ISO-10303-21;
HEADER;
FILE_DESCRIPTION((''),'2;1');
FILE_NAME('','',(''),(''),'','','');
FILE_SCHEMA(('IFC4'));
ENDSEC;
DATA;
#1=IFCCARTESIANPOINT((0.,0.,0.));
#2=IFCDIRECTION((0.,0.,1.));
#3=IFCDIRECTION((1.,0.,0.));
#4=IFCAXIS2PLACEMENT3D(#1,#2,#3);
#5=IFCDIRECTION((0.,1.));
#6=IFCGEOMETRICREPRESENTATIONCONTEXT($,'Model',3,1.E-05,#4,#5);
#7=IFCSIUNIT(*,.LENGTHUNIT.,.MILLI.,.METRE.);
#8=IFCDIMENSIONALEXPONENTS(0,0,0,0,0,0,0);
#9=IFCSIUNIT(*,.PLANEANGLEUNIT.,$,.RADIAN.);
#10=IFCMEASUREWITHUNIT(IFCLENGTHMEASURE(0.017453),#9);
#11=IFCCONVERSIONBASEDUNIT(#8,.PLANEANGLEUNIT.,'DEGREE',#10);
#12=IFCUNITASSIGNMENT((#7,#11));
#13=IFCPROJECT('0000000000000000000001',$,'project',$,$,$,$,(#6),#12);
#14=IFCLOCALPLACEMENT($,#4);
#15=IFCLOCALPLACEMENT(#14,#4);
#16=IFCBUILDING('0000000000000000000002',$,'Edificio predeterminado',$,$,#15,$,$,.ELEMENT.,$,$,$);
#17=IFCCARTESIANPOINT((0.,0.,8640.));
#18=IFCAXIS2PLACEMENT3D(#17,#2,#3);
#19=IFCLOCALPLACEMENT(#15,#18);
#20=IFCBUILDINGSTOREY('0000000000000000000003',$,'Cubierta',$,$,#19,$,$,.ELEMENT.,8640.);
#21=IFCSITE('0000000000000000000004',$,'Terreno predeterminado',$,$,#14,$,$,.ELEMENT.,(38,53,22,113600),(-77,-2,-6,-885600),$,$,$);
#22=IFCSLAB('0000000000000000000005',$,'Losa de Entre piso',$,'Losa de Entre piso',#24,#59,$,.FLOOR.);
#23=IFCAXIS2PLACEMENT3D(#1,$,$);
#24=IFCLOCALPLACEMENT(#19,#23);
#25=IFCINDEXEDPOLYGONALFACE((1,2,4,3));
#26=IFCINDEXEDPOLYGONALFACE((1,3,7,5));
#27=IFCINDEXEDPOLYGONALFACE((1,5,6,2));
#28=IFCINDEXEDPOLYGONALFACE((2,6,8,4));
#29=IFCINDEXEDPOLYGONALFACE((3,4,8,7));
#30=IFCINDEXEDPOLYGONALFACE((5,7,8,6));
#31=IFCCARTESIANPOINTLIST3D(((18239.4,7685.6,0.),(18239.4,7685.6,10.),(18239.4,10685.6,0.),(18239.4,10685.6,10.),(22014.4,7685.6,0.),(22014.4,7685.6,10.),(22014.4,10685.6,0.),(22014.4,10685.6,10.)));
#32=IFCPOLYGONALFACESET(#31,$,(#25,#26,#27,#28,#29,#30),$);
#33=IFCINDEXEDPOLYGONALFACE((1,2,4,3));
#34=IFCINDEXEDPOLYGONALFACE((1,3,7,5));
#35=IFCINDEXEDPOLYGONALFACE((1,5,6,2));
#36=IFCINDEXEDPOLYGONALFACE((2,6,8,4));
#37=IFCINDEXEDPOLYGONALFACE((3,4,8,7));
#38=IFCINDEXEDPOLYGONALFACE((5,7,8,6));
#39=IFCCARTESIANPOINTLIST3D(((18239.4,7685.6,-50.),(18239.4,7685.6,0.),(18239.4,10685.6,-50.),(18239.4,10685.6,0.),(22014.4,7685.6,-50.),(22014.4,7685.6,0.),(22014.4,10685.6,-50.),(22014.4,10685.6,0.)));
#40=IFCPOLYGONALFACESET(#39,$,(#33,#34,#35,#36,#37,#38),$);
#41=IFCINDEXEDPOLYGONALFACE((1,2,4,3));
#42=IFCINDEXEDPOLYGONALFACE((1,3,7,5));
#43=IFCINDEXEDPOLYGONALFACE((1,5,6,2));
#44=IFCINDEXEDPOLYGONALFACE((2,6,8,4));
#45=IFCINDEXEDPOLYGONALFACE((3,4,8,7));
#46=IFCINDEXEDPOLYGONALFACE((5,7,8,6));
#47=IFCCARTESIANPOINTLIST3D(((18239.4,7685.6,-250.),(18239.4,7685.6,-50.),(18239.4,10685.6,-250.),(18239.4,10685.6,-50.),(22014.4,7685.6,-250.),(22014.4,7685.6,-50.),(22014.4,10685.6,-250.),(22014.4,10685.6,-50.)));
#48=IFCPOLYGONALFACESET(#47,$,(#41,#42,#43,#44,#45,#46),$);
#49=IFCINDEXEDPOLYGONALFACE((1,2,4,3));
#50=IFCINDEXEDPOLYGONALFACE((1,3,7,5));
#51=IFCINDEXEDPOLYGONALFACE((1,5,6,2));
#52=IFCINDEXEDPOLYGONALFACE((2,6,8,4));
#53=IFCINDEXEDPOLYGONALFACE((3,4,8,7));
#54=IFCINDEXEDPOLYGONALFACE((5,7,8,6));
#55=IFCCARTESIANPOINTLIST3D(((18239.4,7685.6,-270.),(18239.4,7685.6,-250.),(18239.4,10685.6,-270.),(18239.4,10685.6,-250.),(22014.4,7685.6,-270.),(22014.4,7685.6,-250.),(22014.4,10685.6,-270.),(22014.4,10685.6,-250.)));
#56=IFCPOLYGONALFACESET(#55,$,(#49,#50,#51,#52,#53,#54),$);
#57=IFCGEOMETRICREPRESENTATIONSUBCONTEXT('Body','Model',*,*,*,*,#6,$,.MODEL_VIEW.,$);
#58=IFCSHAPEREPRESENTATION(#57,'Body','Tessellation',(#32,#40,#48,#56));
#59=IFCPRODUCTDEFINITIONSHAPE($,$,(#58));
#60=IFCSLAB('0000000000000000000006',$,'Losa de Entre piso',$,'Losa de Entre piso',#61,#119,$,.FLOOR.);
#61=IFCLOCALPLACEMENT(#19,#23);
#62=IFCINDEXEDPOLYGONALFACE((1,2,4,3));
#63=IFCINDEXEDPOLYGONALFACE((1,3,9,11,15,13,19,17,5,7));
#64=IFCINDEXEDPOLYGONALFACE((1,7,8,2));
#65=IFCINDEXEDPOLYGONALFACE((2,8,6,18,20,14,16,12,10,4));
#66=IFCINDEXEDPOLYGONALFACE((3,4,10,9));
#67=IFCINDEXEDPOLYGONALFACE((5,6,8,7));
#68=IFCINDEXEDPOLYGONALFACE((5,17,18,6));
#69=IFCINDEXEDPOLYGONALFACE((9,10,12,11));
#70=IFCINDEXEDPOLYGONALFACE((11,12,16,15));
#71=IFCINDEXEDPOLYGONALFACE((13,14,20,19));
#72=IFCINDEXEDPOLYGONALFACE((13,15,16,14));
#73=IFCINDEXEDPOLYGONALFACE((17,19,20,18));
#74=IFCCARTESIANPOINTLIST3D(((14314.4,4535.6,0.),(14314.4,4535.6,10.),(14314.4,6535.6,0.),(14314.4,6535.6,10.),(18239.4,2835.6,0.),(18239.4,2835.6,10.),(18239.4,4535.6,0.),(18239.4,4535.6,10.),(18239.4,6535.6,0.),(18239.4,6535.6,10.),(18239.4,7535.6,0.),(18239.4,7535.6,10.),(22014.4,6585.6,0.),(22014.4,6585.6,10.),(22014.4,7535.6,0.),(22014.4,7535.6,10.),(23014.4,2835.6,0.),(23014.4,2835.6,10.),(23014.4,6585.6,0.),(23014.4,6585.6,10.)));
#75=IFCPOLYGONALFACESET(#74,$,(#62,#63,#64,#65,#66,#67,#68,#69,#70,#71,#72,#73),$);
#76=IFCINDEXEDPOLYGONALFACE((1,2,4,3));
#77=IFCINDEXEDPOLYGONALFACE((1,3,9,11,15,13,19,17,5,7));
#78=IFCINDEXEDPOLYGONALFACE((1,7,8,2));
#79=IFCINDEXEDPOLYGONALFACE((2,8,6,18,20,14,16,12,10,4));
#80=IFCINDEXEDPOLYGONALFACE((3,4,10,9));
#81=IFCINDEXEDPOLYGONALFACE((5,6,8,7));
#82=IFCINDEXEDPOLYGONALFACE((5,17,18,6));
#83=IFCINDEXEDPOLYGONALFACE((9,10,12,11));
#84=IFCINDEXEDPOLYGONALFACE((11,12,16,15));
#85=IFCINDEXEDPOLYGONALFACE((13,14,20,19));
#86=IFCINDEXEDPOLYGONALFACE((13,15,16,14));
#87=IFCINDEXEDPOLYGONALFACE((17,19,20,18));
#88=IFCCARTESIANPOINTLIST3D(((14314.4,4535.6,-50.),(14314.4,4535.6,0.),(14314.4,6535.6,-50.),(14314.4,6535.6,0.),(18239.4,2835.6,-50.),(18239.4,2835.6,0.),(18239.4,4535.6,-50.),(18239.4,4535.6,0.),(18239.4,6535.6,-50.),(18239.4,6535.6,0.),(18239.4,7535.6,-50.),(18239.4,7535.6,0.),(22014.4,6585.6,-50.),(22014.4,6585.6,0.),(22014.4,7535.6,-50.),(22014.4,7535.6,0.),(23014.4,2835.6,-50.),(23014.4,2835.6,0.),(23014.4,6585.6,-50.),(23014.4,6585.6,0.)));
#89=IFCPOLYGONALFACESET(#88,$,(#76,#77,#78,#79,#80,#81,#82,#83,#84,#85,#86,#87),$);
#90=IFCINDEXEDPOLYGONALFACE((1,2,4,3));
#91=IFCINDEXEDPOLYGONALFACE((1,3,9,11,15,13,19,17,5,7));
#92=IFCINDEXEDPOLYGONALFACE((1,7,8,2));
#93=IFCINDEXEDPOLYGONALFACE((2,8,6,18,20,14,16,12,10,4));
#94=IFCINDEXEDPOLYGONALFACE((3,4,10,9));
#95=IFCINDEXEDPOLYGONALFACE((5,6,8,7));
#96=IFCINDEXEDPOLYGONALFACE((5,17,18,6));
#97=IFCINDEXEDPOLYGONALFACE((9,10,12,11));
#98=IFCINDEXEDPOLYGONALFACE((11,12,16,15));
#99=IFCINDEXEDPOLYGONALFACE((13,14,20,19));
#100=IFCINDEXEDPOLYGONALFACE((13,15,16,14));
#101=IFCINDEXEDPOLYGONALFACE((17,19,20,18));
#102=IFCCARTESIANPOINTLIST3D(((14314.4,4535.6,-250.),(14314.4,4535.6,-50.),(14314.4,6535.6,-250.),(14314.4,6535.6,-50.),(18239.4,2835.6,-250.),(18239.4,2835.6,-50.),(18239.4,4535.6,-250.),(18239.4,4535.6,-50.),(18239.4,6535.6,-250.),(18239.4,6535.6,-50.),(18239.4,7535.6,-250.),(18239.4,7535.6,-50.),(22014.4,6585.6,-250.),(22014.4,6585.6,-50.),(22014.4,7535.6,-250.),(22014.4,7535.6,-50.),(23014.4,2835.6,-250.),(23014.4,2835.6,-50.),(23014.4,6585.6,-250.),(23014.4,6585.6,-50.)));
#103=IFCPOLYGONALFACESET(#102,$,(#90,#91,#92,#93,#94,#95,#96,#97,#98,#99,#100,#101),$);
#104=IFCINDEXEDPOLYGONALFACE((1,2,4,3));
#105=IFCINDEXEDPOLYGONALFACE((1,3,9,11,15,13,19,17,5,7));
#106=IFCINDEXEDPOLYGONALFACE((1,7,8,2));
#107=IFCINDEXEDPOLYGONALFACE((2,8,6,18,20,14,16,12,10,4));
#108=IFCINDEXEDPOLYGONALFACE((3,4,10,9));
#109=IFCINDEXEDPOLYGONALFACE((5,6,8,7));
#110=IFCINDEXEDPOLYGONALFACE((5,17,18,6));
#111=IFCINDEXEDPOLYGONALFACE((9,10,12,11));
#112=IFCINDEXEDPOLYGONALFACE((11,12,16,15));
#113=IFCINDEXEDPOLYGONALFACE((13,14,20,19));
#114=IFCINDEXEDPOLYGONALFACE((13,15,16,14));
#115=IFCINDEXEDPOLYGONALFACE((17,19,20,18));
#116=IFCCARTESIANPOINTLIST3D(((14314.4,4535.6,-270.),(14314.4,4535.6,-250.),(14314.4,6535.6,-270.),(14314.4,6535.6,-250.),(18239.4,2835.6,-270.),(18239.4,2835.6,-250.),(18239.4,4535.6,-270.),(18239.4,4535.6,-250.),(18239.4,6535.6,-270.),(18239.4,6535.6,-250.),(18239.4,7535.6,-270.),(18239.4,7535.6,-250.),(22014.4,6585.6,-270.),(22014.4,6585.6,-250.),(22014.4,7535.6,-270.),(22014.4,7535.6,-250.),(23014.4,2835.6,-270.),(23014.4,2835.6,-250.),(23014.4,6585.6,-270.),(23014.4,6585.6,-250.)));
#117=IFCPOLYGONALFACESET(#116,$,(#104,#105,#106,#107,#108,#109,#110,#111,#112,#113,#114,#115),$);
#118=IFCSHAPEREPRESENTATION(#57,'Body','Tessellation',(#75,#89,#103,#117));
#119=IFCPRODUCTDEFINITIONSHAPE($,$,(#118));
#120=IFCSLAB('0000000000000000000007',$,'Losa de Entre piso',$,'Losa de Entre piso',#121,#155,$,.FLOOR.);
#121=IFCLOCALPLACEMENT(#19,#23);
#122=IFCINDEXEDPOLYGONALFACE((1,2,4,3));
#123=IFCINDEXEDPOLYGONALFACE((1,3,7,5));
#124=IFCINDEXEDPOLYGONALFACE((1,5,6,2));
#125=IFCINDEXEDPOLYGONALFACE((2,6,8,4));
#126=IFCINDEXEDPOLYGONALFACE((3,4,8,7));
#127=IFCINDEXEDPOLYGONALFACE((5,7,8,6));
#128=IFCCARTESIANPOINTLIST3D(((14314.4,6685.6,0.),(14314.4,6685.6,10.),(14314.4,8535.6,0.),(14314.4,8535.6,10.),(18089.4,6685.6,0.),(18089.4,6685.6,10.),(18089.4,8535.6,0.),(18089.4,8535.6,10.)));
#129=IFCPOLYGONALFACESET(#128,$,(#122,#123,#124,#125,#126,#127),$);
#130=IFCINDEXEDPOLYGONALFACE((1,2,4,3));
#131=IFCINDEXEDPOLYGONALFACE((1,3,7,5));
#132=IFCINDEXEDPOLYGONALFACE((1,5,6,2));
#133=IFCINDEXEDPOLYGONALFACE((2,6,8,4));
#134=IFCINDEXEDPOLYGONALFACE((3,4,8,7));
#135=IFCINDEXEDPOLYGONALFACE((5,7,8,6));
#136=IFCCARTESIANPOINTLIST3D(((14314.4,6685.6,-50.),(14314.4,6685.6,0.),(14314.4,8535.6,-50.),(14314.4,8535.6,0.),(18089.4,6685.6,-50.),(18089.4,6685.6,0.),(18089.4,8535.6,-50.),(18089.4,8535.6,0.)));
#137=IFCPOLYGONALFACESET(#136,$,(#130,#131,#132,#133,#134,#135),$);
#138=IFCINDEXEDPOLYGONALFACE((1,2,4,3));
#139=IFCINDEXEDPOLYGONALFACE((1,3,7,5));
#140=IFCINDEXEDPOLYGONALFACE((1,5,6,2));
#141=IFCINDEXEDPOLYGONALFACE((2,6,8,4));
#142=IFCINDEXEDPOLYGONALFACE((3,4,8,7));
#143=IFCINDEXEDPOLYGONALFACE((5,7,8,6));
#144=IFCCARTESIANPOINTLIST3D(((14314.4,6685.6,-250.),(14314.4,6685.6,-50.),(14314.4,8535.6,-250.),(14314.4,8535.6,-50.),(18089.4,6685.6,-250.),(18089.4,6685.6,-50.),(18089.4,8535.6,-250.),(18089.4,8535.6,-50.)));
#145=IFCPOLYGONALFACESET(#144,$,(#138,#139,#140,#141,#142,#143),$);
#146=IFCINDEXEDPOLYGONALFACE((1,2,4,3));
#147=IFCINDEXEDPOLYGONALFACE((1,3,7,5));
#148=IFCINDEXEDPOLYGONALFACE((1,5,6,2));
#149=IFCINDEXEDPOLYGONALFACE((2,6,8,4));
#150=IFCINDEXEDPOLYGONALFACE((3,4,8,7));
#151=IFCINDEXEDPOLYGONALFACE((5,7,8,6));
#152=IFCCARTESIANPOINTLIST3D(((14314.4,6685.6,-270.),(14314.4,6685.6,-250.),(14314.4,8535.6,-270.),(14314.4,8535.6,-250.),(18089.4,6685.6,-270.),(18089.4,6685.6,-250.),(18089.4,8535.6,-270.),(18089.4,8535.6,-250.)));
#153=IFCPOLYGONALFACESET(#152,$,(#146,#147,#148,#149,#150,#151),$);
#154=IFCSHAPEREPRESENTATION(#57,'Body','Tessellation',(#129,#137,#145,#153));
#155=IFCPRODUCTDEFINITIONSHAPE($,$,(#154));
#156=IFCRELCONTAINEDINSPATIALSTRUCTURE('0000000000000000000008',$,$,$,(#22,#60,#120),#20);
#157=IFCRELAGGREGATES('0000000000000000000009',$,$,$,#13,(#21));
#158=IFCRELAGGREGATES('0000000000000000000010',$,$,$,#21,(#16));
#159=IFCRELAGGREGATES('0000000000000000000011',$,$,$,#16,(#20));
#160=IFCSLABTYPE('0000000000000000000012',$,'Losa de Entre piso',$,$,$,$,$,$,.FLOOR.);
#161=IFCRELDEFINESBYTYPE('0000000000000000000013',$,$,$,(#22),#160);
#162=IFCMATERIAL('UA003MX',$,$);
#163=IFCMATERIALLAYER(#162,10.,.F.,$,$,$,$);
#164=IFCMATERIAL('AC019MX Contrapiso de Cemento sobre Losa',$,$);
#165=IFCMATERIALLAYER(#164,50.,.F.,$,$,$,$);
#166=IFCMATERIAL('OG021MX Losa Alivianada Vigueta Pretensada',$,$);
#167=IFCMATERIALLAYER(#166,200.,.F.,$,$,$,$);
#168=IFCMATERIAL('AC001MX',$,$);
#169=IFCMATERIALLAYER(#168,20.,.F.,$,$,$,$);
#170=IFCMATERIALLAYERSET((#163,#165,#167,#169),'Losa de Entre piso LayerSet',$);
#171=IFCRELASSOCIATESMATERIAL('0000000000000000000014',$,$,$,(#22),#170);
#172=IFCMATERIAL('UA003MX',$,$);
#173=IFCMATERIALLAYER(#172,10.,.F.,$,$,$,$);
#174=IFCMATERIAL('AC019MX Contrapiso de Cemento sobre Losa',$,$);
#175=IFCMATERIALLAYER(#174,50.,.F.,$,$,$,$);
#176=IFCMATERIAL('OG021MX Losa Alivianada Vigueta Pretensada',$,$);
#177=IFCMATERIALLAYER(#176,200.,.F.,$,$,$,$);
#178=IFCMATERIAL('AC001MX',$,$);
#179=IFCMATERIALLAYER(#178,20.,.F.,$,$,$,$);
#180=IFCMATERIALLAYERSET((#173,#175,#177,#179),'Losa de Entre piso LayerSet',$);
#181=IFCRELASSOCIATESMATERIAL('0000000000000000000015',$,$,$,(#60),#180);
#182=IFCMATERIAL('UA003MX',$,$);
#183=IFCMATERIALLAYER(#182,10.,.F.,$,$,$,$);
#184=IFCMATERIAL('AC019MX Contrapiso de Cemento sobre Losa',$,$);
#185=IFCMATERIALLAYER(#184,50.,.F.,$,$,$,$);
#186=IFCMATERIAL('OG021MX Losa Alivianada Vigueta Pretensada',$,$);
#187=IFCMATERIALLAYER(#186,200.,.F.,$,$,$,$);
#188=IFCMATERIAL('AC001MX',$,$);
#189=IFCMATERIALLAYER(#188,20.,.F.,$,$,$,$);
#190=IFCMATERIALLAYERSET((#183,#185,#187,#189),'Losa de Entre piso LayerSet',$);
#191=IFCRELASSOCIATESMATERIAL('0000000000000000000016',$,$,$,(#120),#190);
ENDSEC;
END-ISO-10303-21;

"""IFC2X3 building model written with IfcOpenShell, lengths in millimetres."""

from ifc_helpers import new_model, entity, si_unit, converted_unit, direction, frame, origin_with_axes, place, context, subcontext, project, spatial, polyline, outline, extrude, material, layer, layer_set, layer_usage, type_object, element, save


model = new_model("IFC2X3")

# Units and contexts
model_context = context("Model", 3, precision=1e-05, world=origin_with_axes(), true_north=direction((0.0, 1.0)))
body_context = subcontext(model_context, "Body", "Model", "MODEL_VIEW")
ifc_project = project(units=[si_unit("LENGTHUNIT", "METRE", prefix="MILLI"), converted_unit("PLANEANGLEUNIT", "DEGREE", entity("IfcLengthMeasure", 0.017453), si_unit("PLANEANGLEUNIT", "RADIAN"), dimensions=[0, 0, 0, 0, 0, 0, 0])], contexts=[model_context])

# Site, building, storey
site_placement = place(None, origin_with_axes())
site = spatial("IfcSite", under=ifc_project, at=site_placement, Name="Terreno predeterminado", CompositionType="ELEMENT", RefLatitude=(38, 53, 22, 113600), RefLongitude=(-77, -2, -6, -885600))
building_placement = place(site_placement, origin_with_axes())
building = spatial("IfcBuilding", under=site, at=building_placement, Name="Edificio predeterminado", CompositionType="ELEMENT")
storey_placement = place(building_placement, frame((0.0, 0.0, 8640.0), z_axis=(0.0, 0.0, 1.0), x_axis=(1.0, 0.0, 0.0)))
storey = spatial("IfcBuildingStorey", under=building, at=storey_placement, Name="Cubierta", CompositionType="ELEMENT", Elevation=8640.0)

# Slabs
ifc_material_1 = material(Name="UA003MX")
ifc_layer_1 = layer(ifc_material_1, 10.0, ventilated=False)
ifc_material_2 = material(Name="AC019MX Contrapiso de Cemento sobre Losa")
ifc_layer_2 = layer(ifc_material_2, 50.0, ventilated=False)
ifc_material_3 = material(Name="OG021MX Losa Alivianada Vigueta Pretensada")
ifc_layer_3 = layer(ifc_material_3, 200.0, ventilated=False)
ifc_material_4 = material(Name="AC001MX")
ifc_layer_4 = layer(ifc_material_4, 20.0, ventilated=False)
ifc_layer_set_1 = layer_set([ifc_layer_1, ifc_layer_2, ifc_layer_3, ifc_layer_4], Name="Losa de Entre piso LayerSet")
ifc_layer_usage_1 = layer_usage(ifc_layer_set_1, "AXIS3", "NEGATIVE", 0.0)
slab_type = type_object("IfcSlabType", Name="Losa de Entre piso", PredefinedType="FLOOR")
slab_1_placement = place(storey_placement, frame((0.0, 0.0, -8640.0), z_axis=(0.0, 0.0, 1.0), x_axis=(1.0, 0.0, 0.0)))
element("IfcSlab", 1, at=slab_1_placement, inside=storey, type_object=slab_type, material=ifc_layer_usage_1, Name="Losa de Entre piso", ObjectType="Losa de Entre piso", PredefinedType="FLOOR", context=body_context, shape_type="SweptSolid", body=[
    extrude(outline(polyline([(0.0, 3000.0), (3775.0, 3000.0), (3775.0, 0.0), (0.0, 0.0), (0.0, 3000.0)])), frame((22014.4, 7685.6, 8640.0), z_axis=(0.0, 0.0, -1.0), x_axis=(-1.0, 0.0, 0.0)), (0.0, 0.0, -1.0), 10.0),
    extrude(outline(polyline([(0.0, 3000.0), (3775.0, 3000.0), (3775.0, 0.0), (0.0, 0.0), (0.0, 3000.0)])), frame((22014.4, 7685.6, 8590.0), z_axis=(0.0, 0.0, -1.0), x_axis=(-1.0, 0.0, 0.0)), (0.0, 0.0, -1.0), 50.0),
    extrude(outline(polyline([(0.0, 3000.0), (3775.0, 3000.0), (3775.0, 0.0), (0.0, 0.0), (0.0, 3000.0)])), frame((22014.4, 7685.6, 8390.0), z_axis=(0.0, 0.0, -1.0), x_axis=(-1.0, 0.0, 0.0)), (0.0, 0.0, -1.0), 200.0),
    extrude(outline(polyline([(0.0, 3000.0), (3775.0, 3000.0), (3775.0, 0.0), (0.0, 0.0), (0.0, 3000.0)])), frame((22014.4, 7685.6, 8370.0), z_axis=(0.0, 0.0, -1.0), x_axis=(-1.0, 0.0, 0.0)), (0.0, 0.0, -1.0), 20.0),
])
ifc_material_5 = material(Name="UA003MX")
ifc_layer_5 = layer(ifc_material_5, 10.0, ventilated=False)
ifc_material_6 = material(Name="AC019MX Contrapiso de Cemento sobre Losa")
ifc_layer_6 = layer(ifc_material_6, 50.0, ventilated=False)
ifc_material_7 = material(Name="OG021MX Losa Alivianada Vigueta Pretensada")
ifc_layer_7 = layer(ifc_material_7, 200.0, ventilated=False)
ifc_material_8 = material(Name="AC001MX")
ifc_layer_8 = layer(ifc_material_8, 20.0, ventilated=False)
ifc_layer_set_2 = layer_set([ifc_layer_5, ifc_layer_6, ifc_layer_7, ifc_layer_8], Name="Losa de Entre piso LayerSet")
ifc_layer_usage_2 = layer_usage(ifc_layer_set_2, "AXIS3", "NEGATIVE", 0.0)
slab_2_placement = place(storey_placement, frame((0.0, 0.0, -8640.0), z_axis=(0.0, 0.0, 1.0), x_axis=(1.0, 0.0, 0.0)))
element("IfcSlab", 2, at=slab_2_placement, inside=storey, material=ifc_layer_usage_2, Name="Losa de Entre piso", ObjectType="Losa de Entre piso", PredefinedType="FLOOR", context=body_context, shape_type="SweptSolid", body=[
    extrude(outline(polyline([(0.0, 1000.0), (-3925.0, 1000.0), (-3925.0, 3000.0), (0.0, 3000.0), (0.0, 4700.0), (4775.0, 4700.0), (4775.0, 950.0), (3775.0, 950.0), (3775.0, 0.0), (0.0, 0.0), (0.0, 1000.0)])), frame((18239.4, 7535.6, 8640.0), z_axis=(0.0, 0.0, -1.0), x_axis=(1.0, 0.0, 0.0)), (0.0, 0.0, -1.0), 10.0),
    extrude(outline(polyline([(0.0, 1000.0), (-3925.0, 1000.0), (-3925.0, 3000.0), (0.0, 3000.0), (0.0, 4700.0), (4775.0, 4700.0), (4775.0, 950.0), (3775.0, 950.0), (3775.0, 0.0), (0.0, 0.0), (0.0, 1000.0)])), frame((18239.4, 7535.6, 8590.0), z_axis=(0.0, 0.0, -1.0), x_axis=(1.0, 0.0, 0.0)), (0.0, 0.0, -1.0), 50.0),
    extrude(outline(polyline([(0.0, 1000.0), (-3925.0, 1000.0), (-3925.0, 3000.0), (0.0, 3000.0), (0.0, 4700.0), (4775.0, 4700.0), (4775.0, 950.0), (3775.0, 950.0), (3775.0, 0.0), (0.0, 0.0), (0.0, 1000.0)])), frame((18239.4, 7535.6, 8390.0), z_axis=(0.0, 0.0, -1.0), x_axis=(1.0, 0.0, 0.0)), (0.0, 0.0, -1.0), 200.0),
    extrude(outline(polyline([(0.0, 1000.0), (-3925.0, 1000.0), (-3925.0, 3000.0), (0.0, 3000.0), (0.0, 4700.0), (4775.0, 4700.0), (4775.0, 950.0), (3775.0, 950.0), (3775.0, 0.0), (0.0, 0.0), (0.0, 1000.0)])), frame((18239.4, 7535.6, 8370.0), z_axis=(0.0, 0.0, -1.0), x_axis=(1.0, 0.0, 0.0)), (0.0, 0.0, -1.0), 20.0),
])
ifc_material_9 = material(Name="UA003MX")
ifc_layer_9 = layer(ifc_material_9, 10.0, ventilated=False)
ifc_material_10 = material(Name="AC019MX Contrapiso de Cemento sobre Losa")
ifc_layer_10 = layer(ifc_material_10, 50.0, ventilated=False)
ifc_material_11 = material(Name="OG021MX Losa Alivianada Vigueta Pretensada")
ifc_layer_11 = layer(ifc_material_11, 200.0, ventilated=False)
ifc_material_12 = material(Name="AC001MX")
ifc_layer_12 = layer(ifc_material_12, 20.0, ventilated=False)
ifc_layer_set_3 = layer_set([ifc_layer_9, ifc_layer_10, ifc_layer_11, ifc_layer_12], Name="Losa de Entre piso LayerSet")
ifc_layer_usage_3 = layer_usage(ifc_layer_set_3, "AXIS3", "NEGATIVE", 0.0)
slab_3_placement = place(storey_placement, frame((0.0, 0.0, -8640.0), z_axis=(0.0, 0.0, 1.0), x_axis=(1.0, 0.0, 0.0)))
element("IfcSlab", 3, at=slab_3_placement, inside=storey, material=ifc_layer_usage_3, Name="Losa de Entre piso", ObjectType="Losa de Entre piso", PredefinedType="FLOOR", context=body_context, shape_type="SweptSolid", body=[
    extrude(outline(polyline([(0.0, 1850.0), (3775.0, 1850.0), (3775.0, 0.0), (0.0, 0.0), (0.0, 1850.0)])), frame((18089.4, 6685.6, 8640.0), z_axis=(0.0, 0.0, -1.0), x_axis=(-1.0, 0.0, 0.0)), (0.0, 0.0, -1.0), 10.0),
    extrude(outline(polyline([(0.0, 1850.0), (3775.0, 1850.0), (3775.0, 0.0), (0.0, 0.0), (0.0, 1850.0)])), frame((18089.4, 6685.6, 8590.0), z_axis=(0.0, 0.0, -1.0), x_axis=(-1.0, 0.0, 0.0)), (0.0, 0.0, -1.0), 50.0),
    extrude(outline(polyline([(0.0, 1850.0), (3775.0, 1850.0), (3775.0, 0.0), (0.0, 0.0), (0.0, 1850.0)])), frame((18089.4, 6685.6, 8390.0), z_axis=(0.0, 0.0, -1.0), x_axis=(-1.0, 0.0, 0.0)), (0.0, 0.0, -1.0), 200.0),
    extrude(outline(polyline([(0.0, 1850.0), (3775.0, 1850.0), (3775.0, 0.0), (0.0, 0.0), (0.0, 1850.0)])), frame((18089.4, 6685.6, 8370.0), z_axis=(0.0, 0.0, -1.0), x_axis=(-1.0, 0.0, 0.0)), (0.0, 0.0, -1.0), 20.0),
])

save(model, "model.ifc")
